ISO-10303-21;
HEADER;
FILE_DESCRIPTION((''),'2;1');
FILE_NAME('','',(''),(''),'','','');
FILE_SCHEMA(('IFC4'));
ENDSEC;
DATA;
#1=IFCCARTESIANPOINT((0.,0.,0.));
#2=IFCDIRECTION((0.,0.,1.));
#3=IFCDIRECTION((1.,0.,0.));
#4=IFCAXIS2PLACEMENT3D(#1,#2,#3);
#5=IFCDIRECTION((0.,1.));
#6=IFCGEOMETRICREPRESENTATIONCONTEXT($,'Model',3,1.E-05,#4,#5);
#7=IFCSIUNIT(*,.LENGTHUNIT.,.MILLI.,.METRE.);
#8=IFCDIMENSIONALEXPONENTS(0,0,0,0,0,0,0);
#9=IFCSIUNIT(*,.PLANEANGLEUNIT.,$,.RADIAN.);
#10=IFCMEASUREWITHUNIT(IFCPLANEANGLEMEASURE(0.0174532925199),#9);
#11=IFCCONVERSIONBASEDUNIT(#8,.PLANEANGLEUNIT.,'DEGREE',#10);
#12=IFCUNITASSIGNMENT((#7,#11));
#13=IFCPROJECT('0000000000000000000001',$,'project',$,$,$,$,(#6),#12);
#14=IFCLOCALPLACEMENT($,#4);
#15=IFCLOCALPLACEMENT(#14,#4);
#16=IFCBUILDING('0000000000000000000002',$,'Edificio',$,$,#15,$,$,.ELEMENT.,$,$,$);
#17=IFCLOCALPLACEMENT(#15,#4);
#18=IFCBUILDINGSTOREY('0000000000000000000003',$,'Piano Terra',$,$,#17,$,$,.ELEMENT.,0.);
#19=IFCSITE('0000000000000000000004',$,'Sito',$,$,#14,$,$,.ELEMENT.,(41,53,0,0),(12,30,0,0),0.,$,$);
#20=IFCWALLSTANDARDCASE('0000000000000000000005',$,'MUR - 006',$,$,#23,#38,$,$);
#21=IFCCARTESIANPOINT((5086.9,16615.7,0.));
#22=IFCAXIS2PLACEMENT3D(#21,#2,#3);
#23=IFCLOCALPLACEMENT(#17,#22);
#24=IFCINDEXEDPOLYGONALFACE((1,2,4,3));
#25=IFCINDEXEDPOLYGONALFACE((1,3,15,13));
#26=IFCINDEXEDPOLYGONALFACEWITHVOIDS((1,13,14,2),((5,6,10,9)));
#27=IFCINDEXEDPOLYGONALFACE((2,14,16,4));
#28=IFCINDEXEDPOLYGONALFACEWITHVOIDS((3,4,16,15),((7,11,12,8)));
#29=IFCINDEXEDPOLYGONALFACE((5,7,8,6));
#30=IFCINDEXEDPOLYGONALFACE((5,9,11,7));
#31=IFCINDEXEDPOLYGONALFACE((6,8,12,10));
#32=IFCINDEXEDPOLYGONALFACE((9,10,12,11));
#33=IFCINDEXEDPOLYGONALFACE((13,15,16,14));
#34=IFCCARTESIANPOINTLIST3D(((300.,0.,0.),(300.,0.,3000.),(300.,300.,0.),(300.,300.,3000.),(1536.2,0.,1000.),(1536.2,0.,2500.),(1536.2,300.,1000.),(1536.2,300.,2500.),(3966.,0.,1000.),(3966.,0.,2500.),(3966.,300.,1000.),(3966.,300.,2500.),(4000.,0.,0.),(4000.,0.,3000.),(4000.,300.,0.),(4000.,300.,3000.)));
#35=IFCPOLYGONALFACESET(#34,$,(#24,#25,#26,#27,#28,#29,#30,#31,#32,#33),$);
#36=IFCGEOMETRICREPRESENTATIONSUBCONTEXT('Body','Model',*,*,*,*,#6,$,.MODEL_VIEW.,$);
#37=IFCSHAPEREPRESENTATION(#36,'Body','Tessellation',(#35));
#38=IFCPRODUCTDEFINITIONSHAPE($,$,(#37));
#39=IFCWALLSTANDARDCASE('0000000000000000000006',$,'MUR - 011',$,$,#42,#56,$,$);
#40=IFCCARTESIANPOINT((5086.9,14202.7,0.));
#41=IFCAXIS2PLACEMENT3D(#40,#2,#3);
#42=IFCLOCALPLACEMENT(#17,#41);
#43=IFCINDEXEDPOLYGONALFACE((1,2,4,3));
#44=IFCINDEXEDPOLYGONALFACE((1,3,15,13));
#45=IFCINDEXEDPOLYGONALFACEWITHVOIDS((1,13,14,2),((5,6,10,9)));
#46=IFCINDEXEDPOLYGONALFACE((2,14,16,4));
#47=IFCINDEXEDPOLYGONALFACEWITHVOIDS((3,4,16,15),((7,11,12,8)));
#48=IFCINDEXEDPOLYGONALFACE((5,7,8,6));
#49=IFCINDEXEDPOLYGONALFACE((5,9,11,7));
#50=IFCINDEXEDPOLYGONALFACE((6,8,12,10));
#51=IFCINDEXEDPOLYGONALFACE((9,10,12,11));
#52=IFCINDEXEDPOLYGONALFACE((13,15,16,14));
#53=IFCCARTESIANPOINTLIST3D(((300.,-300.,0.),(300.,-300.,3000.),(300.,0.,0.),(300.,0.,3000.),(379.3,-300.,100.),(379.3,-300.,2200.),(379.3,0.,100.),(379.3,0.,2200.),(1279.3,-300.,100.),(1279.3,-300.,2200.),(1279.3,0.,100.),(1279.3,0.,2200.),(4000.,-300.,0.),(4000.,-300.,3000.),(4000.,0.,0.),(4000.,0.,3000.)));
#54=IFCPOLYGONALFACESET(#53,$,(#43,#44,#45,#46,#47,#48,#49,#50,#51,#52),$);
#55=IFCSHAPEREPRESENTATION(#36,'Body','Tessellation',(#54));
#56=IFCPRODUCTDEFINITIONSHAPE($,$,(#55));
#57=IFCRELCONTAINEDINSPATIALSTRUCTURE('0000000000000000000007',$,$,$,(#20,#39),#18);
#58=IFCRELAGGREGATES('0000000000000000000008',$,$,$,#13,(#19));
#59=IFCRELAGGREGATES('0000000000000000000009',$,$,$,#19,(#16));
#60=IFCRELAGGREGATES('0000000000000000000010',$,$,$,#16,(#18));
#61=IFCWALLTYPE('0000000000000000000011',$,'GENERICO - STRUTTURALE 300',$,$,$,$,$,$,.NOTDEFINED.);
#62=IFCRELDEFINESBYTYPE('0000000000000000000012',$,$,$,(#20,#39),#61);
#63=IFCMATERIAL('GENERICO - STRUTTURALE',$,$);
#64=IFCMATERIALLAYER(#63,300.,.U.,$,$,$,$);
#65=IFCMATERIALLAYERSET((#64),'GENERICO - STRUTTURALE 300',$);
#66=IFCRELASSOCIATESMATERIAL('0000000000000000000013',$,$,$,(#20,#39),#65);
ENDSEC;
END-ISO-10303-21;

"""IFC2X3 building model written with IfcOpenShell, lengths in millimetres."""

from ifc_helpers import new_model, entity, si_unit, converted_unit, direction, frame, origin_with_axes, origin_2d_with_axis, place, context, subcontext, project, spatial, polyline, rectangle, outline, extrude, material, layer, layer_set, layer_usage, type_object, element, save


model = new_model("IFC2X3")

# Units and contexts
model_context = context("Model", 3, precision=1e-05, world=origin_with_axes(), true_north=direction((0.0, 1.0)))
body_context = subcontext(model_context, "Body", "Model", "MODEL_VIEW")
ifc_project = project(units=[si_unit("LENGTHUNIT", "METRE", prefix="MILLI"), converted_unit("PLANEANGLEUNIT", "DEGREE", entity("IfcPlaneAngleMeasure", 0.0174532925199), si_unit("PLANEANGLEUNIT", "RADIAN"), dimensions=[0, 0, 0, 0, 0, 0, 0])], contexts=[model_context])

# Site, building, storey
site_placement = place(None, origin_with_axes())
site = spatial("IfcSite", under=ifc_project, at=site_placement, Name="Sito", CompositionType="ELEMENT", RefLatitude=(41, 53, 0, 0), RefLongitude=(12, 30, 0, 0), RefElevation=0.0)
building_placement = place(site_placement, origin_with_axes())
building = spatial("IfcBuilding", under=site, at=building_placement, Name="Edificio", CompositionType="ELEMENT")
storey_placement = place(building_placement, origin_with_axes())
storey = spatial("IfcBuildingStorey", under=building, at=storey_placement, Name="Piano Terra", CompositionType="ELEMENT", Elevation=0.0)

# Shared definitions
ifc_material_1 = material(Name="GENERICO - STRUTTURALE")

# Shared definitions
ifc_layer_1 = layer(ifc_material_1, 300.0, ventilated="UNKNOWN")
ifc_layer_set_1 = layer_set([ifc_layer_1], Name="GENERICO - STRUTTURALE 300")
wall_type = type_object("IfcWallType", Name="GENERICO - STRUTTURALE 300", PredefinedType="NOTDEFINED")

# Wall, opening
ifc_layer_usage_1 = layer_usage(ifc_layer_set_1, "AXIS2", "POSITIVE", 0.0)
wall_1_placement = place(storey_placement, frame((5086.9, 16615.7, 0.0), z_axis=(0.0, 0.0, 1.0), x_axis=(1.0, 0.0, 0.0)))
wall_1 = element("IfcWallStandardCase", 1, at=wall_1_placement, inside=storey, type_object=wall_type, material=ifc_layer_usage_1, Name="MUR - 006", context=body_context, shape_type="SweptSolid", body=[
    extrude(outline(polyline([(300.0, 0.0), (4000.0, 0.0), (4000.0, 300.0), (300.0, 300.0), (300.0, 0.0)])), origin_with_axes(), (0.0, 0.0, 1.0), 3000.0),
])
opening_1_placement = place(wall_1_placement, frame((2751.1, 0.0, 1000.0), z_axis=(0.0, 0.0, 1.0), x_axis=(1.0, 0.0, 0.0)))
element("IfcOpeningElement", 2, at=opening_1_placement, cuts=wall_1, context=body_context, shape_type="SweptSolid", body=[
    extrude(rectangle(XDim=2429.7, YDim=1500.0, at=origin_2d_with_axis()), frame((0.0, -300.0, 750.0), z_axis=(0.0, 1.0, 0.0), x_axis=(1.0, 0.0, 0.0)), (0.0, 0.0, 1.0), 900.0),
])

# Wall, opening
ifc_layer_usage_2 = layer_usage(ifc_layer_set_1, "AXIS2", "POSITIVE", -300.0)
wall_2_placement = place(storey_placement, frame((5086.9, 14202.7, 0.0), z_axis=(0.0, 0.0, 1.0), x_axis=(1.0, 0.0, 0.0)))
wall_2 = element("IfcWallStandardCase", 3, at=wall_2_placement, inside=storey, type_object=wall_type, material=ifc_layer_usage_2, Name="MUR - 011", context=body_context, shape_type="SweptSolid", body=[
    extrude(outline(polyline([(300.0, -300.0), (4000.0, -300.0), (4000.0, 0.0), (300.0, 0.0), (300.0, -300.0)])), origin_with_axes(), (0.0, 0.0, 1.0), 3000.0),
])
opening_2_placement = place(wall_2_placement, frame((829.3, 0.0, 100.0), z_axis=(0.0, 0.0, 1.0), x_axis=(1.0, 0.0, 0.0)))
element("IfcOpeningElement", 4, at=opening_2_placement, cuts=wall_2, context=body_context, shape_type="SweptSolid", body=[
    extrude(rectangle(XDim=900.0, YDim=2100.0, at=origin_2d_with_axis()), frame((0.0, -300.0, 1050.0), z_axis=(0.0, 1.0, 0.0), x_axis=(1.0, 0.0, 0.0)), (0.0, 0.0, 1.0), 900.0),
    extrude(rectangle(XDim=974.0, YDim=2137.0, at=origin_2d_with_axis()), frame((0.0, -300.0, 1068.5), z_axis=(0.0, 1.0, 0.0), x_axis=(1.0, 0.0, 0.0)), (0.0, 0.0, -1.0), 300.0),
    extrude(rectangle(XDim=974.0, YDim=2137.0, at=origin_2d_with_axis()), frame((0.0, 0.0, 1068.5), z_axis=(0.0, -1.0, 0.0), x_axis=(1.0, 0.0, 0.0)), (0.0, 0.0, -1.0), 300.0),
])

save(model, "model.ifc")
